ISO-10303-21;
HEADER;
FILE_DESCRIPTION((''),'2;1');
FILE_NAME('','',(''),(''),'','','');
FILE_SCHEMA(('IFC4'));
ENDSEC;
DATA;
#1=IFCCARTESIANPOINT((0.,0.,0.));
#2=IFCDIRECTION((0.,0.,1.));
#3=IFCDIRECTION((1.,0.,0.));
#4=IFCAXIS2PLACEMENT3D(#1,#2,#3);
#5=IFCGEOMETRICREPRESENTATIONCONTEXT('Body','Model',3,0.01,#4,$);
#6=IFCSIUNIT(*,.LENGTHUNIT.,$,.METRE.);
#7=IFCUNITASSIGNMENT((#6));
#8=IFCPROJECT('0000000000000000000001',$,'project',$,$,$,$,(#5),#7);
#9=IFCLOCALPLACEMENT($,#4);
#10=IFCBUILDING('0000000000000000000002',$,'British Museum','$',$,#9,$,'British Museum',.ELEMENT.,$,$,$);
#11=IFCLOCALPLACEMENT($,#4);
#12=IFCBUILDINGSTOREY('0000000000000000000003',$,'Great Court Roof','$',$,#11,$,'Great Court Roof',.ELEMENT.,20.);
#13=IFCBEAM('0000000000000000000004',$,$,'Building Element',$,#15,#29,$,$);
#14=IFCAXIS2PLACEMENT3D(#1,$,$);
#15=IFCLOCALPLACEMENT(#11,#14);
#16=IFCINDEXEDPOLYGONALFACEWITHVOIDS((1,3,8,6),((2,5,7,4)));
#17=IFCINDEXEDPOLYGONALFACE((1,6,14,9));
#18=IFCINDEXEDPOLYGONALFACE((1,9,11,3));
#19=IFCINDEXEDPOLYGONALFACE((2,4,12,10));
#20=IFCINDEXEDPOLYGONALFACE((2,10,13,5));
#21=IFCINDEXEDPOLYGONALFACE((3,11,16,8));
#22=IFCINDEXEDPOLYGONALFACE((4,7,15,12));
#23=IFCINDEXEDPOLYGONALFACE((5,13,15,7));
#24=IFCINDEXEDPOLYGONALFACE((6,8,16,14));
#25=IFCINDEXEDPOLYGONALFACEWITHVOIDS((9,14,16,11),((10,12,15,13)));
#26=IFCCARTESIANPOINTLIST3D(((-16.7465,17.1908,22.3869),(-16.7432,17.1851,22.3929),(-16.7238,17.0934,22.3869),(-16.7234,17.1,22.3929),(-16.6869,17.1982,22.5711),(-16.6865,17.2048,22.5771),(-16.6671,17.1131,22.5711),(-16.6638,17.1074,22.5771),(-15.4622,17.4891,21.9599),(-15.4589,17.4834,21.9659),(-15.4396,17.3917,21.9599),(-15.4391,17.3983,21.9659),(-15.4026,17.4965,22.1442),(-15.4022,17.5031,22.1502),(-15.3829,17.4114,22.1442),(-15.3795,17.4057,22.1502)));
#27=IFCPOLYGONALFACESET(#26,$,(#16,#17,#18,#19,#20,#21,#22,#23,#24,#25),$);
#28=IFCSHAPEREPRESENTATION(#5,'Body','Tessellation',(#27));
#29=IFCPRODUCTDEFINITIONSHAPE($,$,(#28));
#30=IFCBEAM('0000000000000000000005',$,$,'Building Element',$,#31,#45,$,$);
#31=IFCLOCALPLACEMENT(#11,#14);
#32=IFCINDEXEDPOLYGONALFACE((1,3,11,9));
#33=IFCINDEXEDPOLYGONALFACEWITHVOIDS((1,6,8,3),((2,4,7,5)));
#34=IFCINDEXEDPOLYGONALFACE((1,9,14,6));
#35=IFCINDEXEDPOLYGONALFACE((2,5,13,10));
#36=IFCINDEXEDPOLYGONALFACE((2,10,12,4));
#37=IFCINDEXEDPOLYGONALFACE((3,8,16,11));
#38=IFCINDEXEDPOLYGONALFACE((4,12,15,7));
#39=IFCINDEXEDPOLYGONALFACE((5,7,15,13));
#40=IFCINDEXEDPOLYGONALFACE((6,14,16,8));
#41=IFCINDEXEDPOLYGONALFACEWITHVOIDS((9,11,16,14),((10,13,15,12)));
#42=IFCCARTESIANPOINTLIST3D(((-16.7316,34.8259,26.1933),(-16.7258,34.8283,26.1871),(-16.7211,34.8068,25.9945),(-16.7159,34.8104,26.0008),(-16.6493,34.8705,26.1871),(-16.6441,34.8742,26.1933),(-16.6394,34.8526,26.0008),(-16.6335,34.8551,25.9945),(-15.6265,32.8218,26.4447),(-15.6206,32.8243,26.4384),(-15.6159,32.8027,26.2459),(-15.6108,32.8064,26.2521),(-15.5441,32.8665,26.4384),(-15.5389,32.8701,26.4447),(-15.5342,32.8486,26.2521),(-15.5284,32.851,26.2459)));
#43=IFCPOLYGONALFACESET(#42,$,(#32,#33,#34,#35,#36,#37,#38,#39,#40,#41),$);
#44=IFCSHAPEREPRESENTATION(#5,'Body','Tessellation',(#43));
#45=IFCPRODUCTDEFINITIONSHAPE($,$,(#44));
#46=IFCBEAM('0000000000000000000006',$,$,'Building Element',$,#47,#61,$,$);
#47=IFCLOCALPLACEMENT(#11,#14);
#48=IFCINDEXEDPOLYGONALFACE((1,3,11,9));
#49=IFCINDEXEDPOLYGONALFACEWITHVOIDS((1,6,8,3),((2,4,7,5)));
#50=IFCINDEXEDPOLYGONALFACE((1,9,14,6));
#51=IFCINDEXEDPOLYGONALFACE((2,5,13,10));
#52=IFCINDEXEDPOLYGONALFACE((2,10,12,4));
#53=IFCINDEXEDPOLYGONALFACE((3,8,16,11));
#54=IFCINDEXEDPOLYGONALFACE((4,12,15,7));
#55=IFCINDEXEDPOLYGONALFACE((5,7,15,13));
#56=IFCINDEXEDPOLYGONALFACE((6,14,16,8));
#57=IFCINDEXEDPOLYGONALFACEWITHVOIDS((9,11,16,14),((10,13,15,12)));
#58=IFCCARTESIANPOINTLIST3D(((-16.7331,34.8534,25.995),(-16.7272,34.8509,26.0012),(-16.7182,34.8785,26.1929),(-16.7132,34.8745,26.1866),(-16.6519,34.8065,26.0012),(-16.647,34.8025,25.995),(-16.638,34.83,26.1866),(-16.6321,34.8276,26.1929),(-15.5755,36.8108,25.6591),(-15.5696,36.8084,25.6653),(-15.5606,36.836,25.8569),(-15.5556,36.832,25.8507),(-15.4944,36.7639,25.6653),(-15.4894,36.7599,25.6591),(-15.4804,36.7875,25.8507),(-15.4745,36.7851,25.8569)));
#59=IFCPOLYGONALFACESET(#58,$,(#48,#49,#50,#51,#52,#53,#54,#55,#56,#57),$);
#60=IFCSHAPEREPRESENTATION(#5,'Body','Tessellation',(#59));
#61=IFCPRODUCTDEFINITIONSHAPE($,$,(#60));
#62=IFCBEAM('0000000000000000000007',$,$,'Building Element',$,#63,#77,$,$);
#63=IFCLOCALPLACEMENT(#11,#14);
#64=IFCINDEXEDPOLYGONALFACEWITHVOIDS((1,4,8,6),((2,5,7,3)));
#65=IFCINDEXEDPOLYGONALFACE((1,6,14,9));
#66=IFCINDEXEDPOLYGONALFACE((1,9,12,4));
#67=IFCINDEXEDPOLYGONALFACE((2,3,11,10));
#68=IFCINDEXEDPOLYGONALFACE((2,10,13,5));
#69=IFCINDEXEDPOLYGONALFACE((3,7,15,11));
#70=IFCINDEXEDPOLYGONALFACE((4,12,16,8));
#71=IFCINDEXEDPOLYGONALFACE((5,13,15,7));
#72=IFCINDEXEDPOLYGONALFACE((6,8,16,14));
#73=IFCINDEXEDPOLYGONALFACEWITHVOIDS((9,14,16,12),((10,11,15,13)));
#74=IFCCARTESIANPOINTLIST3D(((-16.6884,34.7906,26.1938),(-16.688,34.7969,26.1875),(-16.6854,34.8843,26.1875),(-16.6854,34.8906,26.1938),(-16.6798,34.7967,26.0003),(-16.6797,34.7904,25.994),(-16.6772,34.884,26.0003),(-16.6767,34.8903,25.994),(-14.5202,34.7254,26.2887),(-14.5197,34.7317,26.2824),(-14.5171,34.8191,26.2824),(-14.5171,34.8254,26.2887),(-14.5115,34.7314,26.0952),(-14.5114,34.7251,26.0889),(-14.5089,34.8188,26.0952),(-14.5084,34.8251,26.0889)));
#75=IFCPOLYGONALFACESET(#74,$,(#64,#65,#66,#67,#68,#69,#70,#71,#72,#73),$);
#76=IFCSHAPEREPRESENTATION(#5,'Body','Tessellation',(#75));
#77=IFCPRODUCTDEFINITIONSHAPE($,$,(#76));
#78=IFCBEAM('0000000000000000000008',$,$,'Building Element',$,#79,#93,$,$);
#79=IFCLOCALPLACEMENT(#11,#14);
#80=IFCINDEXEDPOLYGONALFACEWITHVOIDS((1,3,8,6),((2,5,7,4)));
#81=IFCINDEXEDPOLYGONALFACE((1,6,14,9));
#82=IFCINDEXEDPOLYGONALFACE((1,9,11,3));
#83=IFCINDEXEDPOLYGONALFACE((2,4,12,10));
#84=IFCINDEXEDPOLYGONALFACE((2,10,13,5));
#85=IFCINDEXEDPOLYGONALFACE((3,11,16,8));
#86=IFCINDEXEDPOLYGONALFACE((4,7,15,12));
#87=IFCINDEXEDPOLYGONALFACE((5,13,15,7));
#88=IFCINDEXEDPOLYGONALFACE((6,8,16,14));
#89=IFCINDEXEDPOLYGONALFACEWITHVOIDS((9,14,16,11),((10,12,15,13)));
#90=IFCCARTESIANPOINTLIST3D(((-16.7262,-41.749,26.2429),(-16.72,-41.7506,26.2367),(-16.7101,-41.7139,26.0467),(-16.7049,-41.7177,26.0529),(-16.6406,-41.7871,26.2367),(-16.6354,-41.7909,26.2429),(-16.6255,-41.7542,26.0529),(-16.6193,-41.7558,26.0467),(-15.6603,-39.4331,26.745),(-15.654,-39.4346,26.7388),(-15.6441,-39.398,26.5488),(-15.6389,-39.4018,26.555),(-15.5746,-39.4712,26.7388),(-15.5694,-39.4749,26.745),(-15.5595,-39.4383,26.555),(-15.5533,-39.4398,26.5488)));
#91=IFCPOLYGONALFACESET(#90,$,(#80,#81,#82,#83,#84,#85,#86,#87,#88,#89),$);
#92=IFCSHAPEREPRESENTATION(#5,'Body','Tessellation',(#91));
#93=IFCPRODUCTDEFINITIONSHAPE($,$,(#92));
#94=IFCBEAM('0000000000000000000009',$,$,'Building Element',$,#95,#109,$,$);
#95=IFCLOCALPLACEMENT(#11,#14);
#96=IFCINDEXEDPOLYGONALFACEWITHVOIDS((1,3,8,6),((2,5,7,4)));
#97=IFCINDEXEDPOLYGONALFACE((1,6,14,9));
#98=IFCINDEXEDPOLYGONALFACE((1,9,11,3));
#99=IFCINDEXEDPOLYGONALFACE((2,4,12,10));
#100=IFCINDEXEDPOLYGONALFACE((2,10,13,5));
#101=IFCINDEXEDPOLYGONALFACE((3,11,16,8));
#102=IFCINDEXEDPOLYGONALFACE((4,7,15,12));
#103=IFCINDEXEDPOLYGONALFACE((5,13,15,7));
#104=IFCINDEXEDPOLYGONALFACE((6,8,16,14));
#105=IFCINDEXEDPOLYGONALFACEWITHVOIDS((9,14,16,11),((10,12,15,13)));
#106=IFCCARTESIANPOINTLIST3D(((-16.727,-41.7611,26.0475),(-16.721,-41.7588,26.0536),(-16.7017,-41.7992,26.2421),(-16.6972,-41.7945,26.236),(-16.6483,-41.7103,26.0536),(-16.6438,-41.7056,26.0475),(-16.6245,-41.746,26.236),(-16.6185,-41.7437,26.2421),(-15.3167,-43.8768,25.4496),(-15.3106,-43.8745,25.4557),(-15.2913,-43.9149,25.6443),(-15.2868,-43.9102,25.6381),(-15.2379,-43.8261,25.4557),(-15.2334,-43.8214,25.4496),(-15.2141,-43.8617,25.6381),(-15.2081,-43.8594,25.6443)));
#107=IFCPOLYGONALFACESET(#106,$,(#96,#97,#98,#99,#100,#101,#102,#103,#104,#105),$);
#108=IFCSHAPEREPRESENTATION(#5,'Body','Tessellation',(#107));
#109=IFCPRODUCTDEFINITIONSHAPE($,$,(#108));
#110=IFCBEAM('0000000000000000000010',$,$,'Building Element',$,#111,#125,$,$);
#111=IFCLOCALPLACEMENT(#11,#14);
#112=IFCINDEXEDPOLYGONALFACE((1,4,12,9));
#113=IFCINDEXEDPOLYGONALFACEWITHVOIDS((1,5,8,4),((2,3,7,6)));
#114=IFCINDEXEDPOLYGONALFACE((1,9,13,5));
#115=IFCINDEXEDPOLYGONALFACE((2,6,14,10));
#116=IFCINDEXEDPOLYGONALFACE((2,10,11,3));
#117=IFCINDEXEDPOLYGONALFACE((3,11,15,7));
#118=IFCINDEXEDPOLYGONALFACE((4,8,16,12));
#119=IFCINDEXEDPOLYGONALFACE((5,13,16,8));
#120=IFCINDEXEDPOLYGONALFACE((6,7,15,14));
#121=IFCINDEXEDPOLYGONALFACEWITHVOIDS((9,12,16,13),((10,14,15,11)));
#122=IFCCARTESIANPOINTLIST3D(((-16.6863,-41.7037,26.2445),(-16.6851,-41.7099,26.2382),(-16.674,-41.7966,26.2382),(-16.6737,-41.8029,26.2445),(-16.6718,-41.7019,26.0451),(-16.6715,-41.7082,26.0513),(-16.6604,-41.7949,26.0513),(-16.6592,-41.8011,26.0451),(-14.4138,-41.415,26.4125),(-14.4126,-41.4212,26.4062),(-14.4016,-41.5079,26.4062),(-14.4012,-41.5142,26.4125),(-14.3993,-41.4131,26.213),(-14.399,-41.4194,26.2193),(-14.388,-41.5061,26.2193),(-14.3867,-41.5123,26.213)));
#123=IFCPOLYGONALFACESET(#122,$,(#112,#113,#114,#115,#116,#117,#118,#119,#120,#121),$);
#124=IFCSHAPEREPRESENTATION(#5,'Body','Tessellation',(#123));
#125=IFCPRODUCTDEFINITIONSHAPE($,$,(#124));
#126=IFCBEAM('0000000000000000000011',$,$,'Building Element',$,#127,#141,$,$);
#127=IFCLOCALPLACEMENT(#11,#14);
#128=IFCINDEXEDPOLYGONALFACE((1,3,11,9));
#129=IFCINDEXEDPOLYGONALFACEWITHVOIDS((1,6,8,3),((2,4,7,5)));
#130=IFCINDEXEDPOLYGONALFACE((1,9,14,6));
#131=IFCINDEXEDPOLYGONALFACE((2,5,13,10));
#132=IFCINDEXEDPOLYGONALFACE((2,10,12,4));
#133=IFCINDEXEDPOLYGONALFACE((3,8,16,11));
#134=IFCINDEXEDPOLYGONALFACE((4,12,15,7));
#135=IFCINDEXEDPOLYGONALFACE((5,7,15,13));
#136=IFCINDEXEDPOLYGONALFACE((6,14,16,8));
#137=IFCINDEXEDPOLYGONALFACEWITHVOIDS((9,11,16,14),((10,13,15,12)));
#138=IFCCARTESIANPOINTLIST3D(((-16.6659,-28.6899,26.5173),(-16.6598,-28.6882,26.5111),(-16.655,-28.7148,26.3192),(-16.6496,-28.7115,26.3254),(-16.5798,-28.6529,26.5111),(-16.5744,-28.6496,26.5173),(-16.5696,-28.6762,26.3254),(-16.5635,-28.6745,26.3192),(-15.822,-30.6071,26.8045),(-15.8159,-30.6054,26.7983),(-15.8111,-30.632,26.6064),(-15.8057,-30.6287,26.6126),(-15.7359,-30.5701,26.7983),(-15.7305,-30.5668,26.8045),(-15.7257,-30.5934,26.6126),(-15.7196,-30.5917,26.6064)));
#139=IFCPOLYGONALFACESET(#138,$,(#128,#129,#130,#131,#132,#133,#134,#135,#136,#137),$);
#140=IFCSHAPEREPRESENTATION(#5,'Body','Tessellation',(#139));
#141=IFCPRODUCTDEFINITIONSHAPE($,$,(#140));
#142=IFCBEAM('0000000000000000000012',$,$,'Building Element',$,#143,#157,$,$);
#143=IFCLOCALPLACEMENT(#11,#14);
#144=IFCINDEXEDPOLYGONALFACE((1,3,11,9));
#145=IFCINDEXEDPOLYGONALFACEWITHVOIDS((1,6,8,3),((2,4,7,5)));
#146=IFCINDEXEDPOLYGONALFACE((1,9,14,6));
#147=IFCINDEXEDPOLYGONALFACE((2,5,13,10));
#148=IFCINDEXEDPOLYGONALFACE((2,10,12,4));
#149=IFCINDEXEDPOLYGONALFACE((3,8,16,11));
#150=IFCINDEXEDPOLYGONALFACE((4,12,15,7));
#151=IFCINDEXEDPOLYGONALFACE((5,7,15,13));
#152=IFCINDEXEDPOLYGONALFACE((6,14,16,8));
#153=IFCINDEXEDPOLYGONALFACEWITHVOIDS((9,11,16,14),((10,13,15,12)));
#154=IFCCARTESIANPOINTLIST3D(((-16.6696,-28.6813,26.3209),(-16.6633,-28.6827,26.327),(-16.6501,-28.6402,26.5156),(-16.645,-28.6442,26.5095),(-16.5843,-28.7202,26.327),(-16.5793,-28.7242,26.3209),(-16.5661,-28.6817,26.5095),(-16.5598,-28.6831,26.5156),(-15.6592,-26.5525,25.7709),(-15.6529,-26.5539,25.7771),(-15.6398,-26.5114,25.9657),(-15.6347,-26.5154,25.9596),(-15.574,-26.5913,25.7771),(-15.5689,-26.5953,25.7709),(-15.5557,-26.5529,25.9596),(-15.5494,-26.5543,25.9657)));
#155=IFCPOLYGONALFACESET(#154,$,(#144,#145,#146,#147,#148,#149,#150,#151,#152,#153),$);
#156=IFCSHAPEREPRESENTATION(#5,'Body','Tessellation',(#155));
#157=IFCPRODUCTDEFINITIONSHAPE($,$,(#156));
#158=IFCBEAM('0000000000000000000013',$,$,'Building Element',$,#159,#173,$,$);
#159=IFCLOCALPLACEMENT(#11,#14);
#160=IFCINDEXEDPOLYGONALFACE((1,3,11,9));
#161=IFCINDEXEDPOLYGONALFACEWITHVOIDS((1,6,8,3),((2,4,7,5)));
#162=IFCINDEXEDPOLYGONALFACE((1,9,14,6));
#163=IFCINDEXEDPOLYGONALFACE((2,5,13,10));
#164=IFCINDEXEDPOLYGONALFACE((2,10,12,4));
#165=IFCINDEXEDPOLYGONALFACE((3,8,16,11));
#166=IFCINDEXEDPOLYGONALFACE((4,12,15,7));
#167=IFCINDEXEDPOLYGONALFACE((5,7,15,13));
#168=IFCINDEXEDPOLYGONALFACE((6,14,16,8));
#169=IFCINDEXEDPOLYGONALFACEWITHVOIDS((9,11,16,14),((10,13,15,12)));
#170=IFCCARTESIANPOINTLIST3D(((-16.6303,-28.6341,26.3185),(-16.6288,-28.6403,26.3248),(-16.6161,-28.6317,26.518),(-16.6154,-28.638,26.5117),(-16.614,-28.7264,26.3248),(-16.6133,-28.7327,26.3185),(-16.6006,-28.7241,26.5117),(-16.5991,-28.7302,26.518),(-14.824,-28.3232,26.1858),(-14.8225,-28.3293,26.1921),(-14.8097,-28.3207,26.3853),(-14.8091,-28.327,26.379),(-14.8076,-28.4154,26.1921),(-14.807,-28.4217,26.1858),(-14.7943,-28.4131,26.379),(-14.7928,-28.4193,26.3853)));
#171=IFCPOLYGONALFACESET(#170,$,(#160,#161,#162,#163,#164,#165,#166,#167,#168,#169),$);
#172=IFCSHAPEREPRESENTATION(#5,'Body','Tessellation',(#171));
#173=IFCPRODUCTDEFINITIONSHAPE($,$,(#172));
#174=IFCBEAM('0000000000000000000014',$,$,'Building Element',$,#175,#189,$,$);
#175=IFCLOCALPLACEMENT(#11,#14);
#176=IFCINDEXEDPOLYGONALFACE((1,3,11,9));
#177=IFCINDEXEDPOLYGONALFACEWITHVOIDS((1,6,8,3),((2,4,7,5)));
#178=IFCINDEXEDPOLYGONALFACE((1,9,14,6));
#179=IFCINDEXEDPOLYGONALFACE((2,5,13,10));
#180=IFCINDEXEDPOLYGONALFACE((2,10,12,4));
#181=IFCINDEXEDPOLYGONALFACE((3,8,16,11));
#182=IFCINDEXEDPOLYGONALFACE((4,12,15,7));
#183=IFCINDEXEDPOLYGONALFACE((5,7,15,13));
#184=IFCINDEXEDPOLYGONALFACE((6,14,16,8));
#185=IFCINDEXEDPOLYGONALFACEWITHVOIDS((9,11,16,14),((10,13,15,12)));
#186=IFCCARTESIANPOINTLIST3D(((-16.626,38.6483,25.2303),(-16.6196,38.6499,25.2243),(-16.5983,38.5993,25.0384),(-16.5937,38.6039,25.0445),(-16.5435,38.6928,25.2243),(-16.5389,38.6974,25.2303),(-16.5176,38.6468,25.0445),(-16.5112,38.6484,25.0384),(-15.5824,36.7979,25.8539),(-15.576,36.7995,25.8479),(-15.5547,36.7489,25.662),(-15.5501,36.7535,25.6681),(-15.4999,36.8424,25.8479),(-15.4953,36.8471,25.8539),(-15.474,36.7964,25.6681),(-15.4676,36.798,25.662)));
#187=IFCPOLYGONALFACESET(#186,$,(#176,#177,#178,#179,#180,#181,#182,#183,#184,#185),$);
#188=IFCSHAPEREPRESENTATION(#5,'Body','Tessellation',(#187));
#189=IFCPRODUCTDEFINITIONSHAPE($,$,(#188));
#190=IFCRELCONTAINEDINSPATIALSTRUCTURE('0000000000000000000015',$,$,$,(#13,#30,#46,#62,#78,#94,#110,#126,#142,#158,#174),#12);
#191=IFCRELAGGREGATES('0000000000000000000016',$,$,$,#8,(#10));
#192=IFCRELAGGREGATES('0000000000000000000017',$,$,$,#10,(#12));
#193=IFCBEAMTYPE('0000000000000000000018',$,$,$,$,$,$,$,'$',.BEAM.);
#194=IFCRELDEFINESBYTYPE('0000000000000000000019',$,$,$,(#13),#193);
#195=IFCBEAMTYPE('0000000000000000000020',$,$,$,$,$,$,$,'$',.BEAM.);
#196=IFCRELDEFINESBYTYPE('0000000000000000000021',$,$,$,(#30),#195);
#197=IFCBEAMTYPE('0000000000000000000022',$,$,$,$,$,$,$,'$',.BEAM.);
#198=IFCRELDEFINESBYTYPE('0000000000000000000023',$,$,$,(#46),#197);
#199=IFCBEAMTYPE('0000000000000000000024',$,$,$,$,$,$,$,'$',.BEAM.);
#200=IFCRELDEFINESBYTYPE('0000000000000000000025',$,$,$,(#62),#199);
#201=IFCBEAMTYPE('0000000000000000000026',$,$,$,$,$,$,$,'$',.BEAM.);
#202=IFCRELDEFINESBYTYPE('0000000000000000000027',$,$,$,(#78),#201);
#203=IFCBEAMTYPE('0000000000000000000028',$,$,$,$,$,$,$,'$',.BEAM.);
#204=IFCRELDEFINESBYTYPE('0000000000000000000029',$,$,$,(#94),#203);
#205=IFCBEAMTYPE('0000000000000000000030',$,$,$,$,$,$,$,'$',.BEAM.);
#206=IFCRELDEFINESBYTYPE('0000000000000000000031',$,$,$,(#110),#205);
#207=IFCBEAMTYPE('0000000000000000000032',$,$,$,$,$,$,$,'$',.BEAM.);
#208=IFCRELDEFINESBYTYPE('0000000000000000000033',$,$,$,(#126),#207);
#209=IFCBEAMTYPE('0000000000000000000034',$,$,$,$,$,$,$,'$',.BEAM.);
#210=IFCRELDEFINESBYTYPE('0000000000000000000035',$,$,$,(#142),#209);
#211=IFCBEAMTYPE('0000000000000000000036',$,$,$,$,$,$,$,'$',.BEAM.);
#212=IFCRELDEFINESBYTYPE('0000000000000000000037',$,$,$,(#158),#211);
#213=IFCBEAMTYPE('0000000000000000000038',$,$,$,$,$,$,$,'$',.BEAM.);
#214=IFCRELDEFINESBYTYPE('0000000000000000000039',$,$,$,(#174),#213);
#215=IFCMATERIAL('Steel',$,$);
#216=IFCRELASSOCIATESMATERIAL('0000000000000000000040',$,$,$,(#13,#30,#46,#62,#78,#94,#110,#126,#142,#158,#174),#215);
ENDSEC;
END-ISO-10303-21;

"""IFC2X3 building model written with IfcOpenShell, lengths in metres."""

from ifc_helpers import new_model, si_unit, frame, origin_with_axes, origin_2d, place, context, project, spatial, hollow_rectangle, extrude, material, type_object, element, save


model = new_model("IFC2X3")

# Units and contexts
model_context = context("Model", 3, precision=0.01, world=origin_with_axes(), identifier="Body")
ifc_project = project(units=[si_unit("LENGTHUNIT", "METRE")], contexts=[model_context])

# Building, storey
building_placement = place(None, origin_with_axes())
building = spatial("IfcBuilding", under=ifc_project, at=building_placement, Name="British Museum", Description="$", LongName="British Museum", CompositionType="ELEMENT")
storey_placement = place(None, origin_with_axes())
storey = spatial("IfcBuildingStorey", under=building, at=storey_placement, Name="Great Court Roof", Description="$", LongName="Great Court Roof", CompositionType="ELEMENT", Elevation=20.0)

# Beams
ifc_material = material(Name="Steel")
beam_type_1 = type_object("IfcBeamType", ElementType="$", PredefinedType="BEAM")
beam_1_placement = place(None, origin_with_axes())
element("IfcBeam", 1, at=beam_1_placement, inside=storey, type_object=beam_type_1, material=ifc_material, Description="Building Element", context=model_context, shape_type="SweptSolid", body=[
    extrude(hollow_rectangle(XDim=0.1, YDim=0.2, WallThickness=0.0063, InnerFilletRadius=0.0, OuterFilletRadius=0.0, at=origin_2d()), frame((-16.7051, 17.1491, 22.482), z_axis=(0.926698, 0.215244, -0.308058), x_axis=(-0.226247, 0.97407, 0.0)), (0.0, 0.0, 1.0), 1.3859),
])
beam_type_2 = type_object("IfcBeamType", ElementType="$", PredefinedType="BEAM")
beam_2_placement = place(None, origin_with_axes())
element("IfcBeam", 2, at=beam_2_placement, inside=storey, type_object=beam_type_2, material=ifc_material, Description="Building Element", context=model_context, shape_type="SweptSolid", body=[
    extrude(hollow_rectangle(XDim=0.1, YDim=0.2, WallThickness=0.0063, InnerFilletRadius=0.0, OuterFilletRadius=0.0, at=origin_2d()), frame((-16.6826, 34.8405, 26.0939), z_axis=(0.480008, -0.870446, 0.109163), x_axis=(0.875679, 0.482894, 0.0)), (0.0, 0.0, 1.0), 2.3024),
])
beam_type_3 = type_object("IfcBeamType", ElementType="$", PredefinedType="BEAM")
beam_3_placement = place(None, origin_with_axes())
element("IfcBeam", 3, at=beam_3_placement, inside=storey, type_object=beam_type_3, material=ifc_material, Description="Building Element", context=model_context, shape_type="SweptSolid", body=[
    extrude(hollow_rectangle(XDim=0.1, YDim=0.2, WallThickness=0.0063, InnerFilletRadius=0.0, OuterFilletRadius=0.0, at=origin_2d()), frame((-16.6826, 34.8405, 26.0939), z_axis=(0.503554, 0.851514, -0.146141), x_axis=(-0.860755, 0.509019, 0.0)), (0.0, 0.0, 1.0), 2.2988),
])
beam_type_4 = type_object("IfcBeamType", ElementType="$", PredefinedType="BEAM")
beam_4_placement = place(None, origin_with_axes())
element("IfcBeam", 4, at=beam_4_placement, inside=storey, type_object=beam_type_4, material=ifc_material, Description="Building Element", context=model_context, shape_type="SweptSolid", body=[
    extrude(hollow_rectangle(XDim=0.1, YDim=0.2, WallThickness=0.0063, InnerFilletRadius=0.0, OuterFilletRadius=0.0, at=origin_2d()), frame((-16.6826, 34.8405, 26.0939), z_axis=(0.998593, -0.030044, 0.043691), x_axis=(0.030072, 0.999548, 0.0)), (0.0, 0.0, 1.0), 2.1713),
])
beam_type_5 = type_object("IfcBeamType", ElementType="$", PredefinedType="BEAM")
beam_5_placement = place(None, origin_with_axes())
element("IfcBeam", 5, at=beam_5_placement, inside=storey, type_object=beam_type_5, material=ifc_material, Description="Building Element", context=model_context, shape_type="SweptSolid", body=[
    extrude(hollow_rectangle(XDim=0.1, YDim=0.2, WallThickness=0.0063, InnerFilletRadius=0.0, OuterFilletRadius=0.0, at=origin_2d()), frame((-16.6728, -41.7524, 26.1448), z_axis=(0.410242, 0.891272, 0.193226), x_axis=(-0.908391, 0.418122, 0.0)), (0.0, 0.0, 1.0), 2.5985),
])
beam_type_6 = type_object("IfcBeamType", ElementType="$", PredefinedType="BEAM")
beam_6_placement = place(None, origin_with_axes())
element("IfcBeam", 6, at=beam_6_placement, inside=storey, type_object=beam_type_6, material=ifc_material, Description="Building Element", context=model_context, shape_type="SweptSolid", body=[
    extrude(hollow_rectangle(XDim=0.1, YDim=0.2, WallThickness=0.0063, InnerFilletRadius=0.0, OuterFilletRadius=0.0, at=origin_2d()), frame((-16.6728, -41.7524, 26.1448), z_axis=(0.53995, -0.809978, -0.228888), x_axis=(0.832067, 0.554675, 0.0)), (0.0, 0.0, 1.0), 2.6121),
])
beam_type_7 = type_object("IfcBeamType", ElementType="$", PredefinedType="BEAM")
beam_7_placement = place(None, origin_with_axes())
element("IfcBeam", 7, at=beam_7_placement, inside=storey, type_object=beam_type_7, material=ifc_material, Description="Building Element", context=model_context, shape_type="SweptSolid", body=[
    extrude(hollow_rectangle(XDim=0.1, YDim=0.2, WallThickness=0.0063, InnerFilletRadius=0.0, OuterFilletRadius=0.0, at=origin_2d()), frame((-16.6728, -41.7524, 26.1448), z_axis=(0.989369, 0.125711, 0.073113), x_axis=(-0.126049, 0.992024, 0.0)), (0.0, 0.0, 1.0), 2.2969),
])
beam_type_8 = type_object("IfcBeamType", ElementType="$", PredefinedType="BEAM")
beam_8_placement = place(None, origin_with_axes())
element("IfcBeam", 8, at=beam_8_placement, inside=storey, type_object=beam_type_8, material=ifc_material, Description="Building Element", context=model_context, shape_type="SweptSolid", body=[
    extrude(hollow_rectangle(XDim=0.1, YDim=0.2, WallThickness=0.0063, InnerFilletRadius=0.0, OuterFilletRadius=0.0, at=origin_2d()), frame((-16.6147, -28.6822, 26.4183), z_axis=(0.399139, -0.906772, 0.135842), x_axis=(0.915256, 0.402874, 0.0)), (0.0, 0.0, 1.0), 2.1143),
])
beam_type_9 = type_object("IfcBeamType", ElementType="$", PredefinedType="BEAM")
beam_9_placement = place(None, origin_with_axes())
element("IfcBeam", 9, at=beam_9_placement, inside=storey, type_object=beam_type_9, material=ifc_material, Description="Building Element", context=model_context, shape_type="SweptSolid", body=[
    extrude(hollow_rectangle(XDim=0.1, YDim=0.2, WallThickness=0.0063, InnerFilletRadius=0.0, OuterFilletRadius=0.0, at=origin_2d()), frame((-16.6147, -28.6822, 26.4183), z_axis=(0.417548, 0.879774, -0.227269), x_axis=(-0.903414, 0.428768, 0.0)), (0.0, 0.0, 1.0), 2.4198),
])
beam_type_10 = type_object("IfcBeamType", ElementType="$", PredefinedType="BEAM")
beam_10_placement = place(None, origin_with_axes())
element("IfcBeam", 10, at=beam_10_placement, inside=storey, type_object=beam_type_10, material=ifc_material, Description="Building Element", context=model_context, shape_type="SweptSolid", body=[
    extrude(hollow_rectangle(XDim=0.1, YDim=0.2, WallThickness=0.0063, InnerFilletRadius=0.0, OuterFilletRadius=0.0, at=origin_2d()), frame((-16.6147, -28.6822, 26.4183), z_axis=(0.982927, 0.169228, -0.07223), x_axis=(-0.169671, 0.985501, 0.0)), (0.0, 0.0, 1.0), 1.8377),
])
beam_type_11 = type_object("IfcBeamType", ElementType="$", PredefinedType="BEAM")
beam_11_placement = place(None, origin_with_axes())
element("IfcBeam", 11, at=beam_11_placement, inside=storey, type_object=beam_type_11, material=ifc_material, Description="Building Element", context=model_context, shape_type="SweptSolid", body=[
    extrude(hollow_rectangle(XDim=0.1, YDim=0.2, WallThickness=0.0063, InnerFilletRadius=0.0, OuterFilletRadius=0.0, at=origin_2d()), frame((-16.5686, 38.6483, 25.1344), z_axis=(0.471357, -0.835756, 0.281663), x_axis=(0.871021, 0.491246, 0.0)), (0.0, 0.0, 1.0), 2.214),
])

save(model, "model.ifc")
